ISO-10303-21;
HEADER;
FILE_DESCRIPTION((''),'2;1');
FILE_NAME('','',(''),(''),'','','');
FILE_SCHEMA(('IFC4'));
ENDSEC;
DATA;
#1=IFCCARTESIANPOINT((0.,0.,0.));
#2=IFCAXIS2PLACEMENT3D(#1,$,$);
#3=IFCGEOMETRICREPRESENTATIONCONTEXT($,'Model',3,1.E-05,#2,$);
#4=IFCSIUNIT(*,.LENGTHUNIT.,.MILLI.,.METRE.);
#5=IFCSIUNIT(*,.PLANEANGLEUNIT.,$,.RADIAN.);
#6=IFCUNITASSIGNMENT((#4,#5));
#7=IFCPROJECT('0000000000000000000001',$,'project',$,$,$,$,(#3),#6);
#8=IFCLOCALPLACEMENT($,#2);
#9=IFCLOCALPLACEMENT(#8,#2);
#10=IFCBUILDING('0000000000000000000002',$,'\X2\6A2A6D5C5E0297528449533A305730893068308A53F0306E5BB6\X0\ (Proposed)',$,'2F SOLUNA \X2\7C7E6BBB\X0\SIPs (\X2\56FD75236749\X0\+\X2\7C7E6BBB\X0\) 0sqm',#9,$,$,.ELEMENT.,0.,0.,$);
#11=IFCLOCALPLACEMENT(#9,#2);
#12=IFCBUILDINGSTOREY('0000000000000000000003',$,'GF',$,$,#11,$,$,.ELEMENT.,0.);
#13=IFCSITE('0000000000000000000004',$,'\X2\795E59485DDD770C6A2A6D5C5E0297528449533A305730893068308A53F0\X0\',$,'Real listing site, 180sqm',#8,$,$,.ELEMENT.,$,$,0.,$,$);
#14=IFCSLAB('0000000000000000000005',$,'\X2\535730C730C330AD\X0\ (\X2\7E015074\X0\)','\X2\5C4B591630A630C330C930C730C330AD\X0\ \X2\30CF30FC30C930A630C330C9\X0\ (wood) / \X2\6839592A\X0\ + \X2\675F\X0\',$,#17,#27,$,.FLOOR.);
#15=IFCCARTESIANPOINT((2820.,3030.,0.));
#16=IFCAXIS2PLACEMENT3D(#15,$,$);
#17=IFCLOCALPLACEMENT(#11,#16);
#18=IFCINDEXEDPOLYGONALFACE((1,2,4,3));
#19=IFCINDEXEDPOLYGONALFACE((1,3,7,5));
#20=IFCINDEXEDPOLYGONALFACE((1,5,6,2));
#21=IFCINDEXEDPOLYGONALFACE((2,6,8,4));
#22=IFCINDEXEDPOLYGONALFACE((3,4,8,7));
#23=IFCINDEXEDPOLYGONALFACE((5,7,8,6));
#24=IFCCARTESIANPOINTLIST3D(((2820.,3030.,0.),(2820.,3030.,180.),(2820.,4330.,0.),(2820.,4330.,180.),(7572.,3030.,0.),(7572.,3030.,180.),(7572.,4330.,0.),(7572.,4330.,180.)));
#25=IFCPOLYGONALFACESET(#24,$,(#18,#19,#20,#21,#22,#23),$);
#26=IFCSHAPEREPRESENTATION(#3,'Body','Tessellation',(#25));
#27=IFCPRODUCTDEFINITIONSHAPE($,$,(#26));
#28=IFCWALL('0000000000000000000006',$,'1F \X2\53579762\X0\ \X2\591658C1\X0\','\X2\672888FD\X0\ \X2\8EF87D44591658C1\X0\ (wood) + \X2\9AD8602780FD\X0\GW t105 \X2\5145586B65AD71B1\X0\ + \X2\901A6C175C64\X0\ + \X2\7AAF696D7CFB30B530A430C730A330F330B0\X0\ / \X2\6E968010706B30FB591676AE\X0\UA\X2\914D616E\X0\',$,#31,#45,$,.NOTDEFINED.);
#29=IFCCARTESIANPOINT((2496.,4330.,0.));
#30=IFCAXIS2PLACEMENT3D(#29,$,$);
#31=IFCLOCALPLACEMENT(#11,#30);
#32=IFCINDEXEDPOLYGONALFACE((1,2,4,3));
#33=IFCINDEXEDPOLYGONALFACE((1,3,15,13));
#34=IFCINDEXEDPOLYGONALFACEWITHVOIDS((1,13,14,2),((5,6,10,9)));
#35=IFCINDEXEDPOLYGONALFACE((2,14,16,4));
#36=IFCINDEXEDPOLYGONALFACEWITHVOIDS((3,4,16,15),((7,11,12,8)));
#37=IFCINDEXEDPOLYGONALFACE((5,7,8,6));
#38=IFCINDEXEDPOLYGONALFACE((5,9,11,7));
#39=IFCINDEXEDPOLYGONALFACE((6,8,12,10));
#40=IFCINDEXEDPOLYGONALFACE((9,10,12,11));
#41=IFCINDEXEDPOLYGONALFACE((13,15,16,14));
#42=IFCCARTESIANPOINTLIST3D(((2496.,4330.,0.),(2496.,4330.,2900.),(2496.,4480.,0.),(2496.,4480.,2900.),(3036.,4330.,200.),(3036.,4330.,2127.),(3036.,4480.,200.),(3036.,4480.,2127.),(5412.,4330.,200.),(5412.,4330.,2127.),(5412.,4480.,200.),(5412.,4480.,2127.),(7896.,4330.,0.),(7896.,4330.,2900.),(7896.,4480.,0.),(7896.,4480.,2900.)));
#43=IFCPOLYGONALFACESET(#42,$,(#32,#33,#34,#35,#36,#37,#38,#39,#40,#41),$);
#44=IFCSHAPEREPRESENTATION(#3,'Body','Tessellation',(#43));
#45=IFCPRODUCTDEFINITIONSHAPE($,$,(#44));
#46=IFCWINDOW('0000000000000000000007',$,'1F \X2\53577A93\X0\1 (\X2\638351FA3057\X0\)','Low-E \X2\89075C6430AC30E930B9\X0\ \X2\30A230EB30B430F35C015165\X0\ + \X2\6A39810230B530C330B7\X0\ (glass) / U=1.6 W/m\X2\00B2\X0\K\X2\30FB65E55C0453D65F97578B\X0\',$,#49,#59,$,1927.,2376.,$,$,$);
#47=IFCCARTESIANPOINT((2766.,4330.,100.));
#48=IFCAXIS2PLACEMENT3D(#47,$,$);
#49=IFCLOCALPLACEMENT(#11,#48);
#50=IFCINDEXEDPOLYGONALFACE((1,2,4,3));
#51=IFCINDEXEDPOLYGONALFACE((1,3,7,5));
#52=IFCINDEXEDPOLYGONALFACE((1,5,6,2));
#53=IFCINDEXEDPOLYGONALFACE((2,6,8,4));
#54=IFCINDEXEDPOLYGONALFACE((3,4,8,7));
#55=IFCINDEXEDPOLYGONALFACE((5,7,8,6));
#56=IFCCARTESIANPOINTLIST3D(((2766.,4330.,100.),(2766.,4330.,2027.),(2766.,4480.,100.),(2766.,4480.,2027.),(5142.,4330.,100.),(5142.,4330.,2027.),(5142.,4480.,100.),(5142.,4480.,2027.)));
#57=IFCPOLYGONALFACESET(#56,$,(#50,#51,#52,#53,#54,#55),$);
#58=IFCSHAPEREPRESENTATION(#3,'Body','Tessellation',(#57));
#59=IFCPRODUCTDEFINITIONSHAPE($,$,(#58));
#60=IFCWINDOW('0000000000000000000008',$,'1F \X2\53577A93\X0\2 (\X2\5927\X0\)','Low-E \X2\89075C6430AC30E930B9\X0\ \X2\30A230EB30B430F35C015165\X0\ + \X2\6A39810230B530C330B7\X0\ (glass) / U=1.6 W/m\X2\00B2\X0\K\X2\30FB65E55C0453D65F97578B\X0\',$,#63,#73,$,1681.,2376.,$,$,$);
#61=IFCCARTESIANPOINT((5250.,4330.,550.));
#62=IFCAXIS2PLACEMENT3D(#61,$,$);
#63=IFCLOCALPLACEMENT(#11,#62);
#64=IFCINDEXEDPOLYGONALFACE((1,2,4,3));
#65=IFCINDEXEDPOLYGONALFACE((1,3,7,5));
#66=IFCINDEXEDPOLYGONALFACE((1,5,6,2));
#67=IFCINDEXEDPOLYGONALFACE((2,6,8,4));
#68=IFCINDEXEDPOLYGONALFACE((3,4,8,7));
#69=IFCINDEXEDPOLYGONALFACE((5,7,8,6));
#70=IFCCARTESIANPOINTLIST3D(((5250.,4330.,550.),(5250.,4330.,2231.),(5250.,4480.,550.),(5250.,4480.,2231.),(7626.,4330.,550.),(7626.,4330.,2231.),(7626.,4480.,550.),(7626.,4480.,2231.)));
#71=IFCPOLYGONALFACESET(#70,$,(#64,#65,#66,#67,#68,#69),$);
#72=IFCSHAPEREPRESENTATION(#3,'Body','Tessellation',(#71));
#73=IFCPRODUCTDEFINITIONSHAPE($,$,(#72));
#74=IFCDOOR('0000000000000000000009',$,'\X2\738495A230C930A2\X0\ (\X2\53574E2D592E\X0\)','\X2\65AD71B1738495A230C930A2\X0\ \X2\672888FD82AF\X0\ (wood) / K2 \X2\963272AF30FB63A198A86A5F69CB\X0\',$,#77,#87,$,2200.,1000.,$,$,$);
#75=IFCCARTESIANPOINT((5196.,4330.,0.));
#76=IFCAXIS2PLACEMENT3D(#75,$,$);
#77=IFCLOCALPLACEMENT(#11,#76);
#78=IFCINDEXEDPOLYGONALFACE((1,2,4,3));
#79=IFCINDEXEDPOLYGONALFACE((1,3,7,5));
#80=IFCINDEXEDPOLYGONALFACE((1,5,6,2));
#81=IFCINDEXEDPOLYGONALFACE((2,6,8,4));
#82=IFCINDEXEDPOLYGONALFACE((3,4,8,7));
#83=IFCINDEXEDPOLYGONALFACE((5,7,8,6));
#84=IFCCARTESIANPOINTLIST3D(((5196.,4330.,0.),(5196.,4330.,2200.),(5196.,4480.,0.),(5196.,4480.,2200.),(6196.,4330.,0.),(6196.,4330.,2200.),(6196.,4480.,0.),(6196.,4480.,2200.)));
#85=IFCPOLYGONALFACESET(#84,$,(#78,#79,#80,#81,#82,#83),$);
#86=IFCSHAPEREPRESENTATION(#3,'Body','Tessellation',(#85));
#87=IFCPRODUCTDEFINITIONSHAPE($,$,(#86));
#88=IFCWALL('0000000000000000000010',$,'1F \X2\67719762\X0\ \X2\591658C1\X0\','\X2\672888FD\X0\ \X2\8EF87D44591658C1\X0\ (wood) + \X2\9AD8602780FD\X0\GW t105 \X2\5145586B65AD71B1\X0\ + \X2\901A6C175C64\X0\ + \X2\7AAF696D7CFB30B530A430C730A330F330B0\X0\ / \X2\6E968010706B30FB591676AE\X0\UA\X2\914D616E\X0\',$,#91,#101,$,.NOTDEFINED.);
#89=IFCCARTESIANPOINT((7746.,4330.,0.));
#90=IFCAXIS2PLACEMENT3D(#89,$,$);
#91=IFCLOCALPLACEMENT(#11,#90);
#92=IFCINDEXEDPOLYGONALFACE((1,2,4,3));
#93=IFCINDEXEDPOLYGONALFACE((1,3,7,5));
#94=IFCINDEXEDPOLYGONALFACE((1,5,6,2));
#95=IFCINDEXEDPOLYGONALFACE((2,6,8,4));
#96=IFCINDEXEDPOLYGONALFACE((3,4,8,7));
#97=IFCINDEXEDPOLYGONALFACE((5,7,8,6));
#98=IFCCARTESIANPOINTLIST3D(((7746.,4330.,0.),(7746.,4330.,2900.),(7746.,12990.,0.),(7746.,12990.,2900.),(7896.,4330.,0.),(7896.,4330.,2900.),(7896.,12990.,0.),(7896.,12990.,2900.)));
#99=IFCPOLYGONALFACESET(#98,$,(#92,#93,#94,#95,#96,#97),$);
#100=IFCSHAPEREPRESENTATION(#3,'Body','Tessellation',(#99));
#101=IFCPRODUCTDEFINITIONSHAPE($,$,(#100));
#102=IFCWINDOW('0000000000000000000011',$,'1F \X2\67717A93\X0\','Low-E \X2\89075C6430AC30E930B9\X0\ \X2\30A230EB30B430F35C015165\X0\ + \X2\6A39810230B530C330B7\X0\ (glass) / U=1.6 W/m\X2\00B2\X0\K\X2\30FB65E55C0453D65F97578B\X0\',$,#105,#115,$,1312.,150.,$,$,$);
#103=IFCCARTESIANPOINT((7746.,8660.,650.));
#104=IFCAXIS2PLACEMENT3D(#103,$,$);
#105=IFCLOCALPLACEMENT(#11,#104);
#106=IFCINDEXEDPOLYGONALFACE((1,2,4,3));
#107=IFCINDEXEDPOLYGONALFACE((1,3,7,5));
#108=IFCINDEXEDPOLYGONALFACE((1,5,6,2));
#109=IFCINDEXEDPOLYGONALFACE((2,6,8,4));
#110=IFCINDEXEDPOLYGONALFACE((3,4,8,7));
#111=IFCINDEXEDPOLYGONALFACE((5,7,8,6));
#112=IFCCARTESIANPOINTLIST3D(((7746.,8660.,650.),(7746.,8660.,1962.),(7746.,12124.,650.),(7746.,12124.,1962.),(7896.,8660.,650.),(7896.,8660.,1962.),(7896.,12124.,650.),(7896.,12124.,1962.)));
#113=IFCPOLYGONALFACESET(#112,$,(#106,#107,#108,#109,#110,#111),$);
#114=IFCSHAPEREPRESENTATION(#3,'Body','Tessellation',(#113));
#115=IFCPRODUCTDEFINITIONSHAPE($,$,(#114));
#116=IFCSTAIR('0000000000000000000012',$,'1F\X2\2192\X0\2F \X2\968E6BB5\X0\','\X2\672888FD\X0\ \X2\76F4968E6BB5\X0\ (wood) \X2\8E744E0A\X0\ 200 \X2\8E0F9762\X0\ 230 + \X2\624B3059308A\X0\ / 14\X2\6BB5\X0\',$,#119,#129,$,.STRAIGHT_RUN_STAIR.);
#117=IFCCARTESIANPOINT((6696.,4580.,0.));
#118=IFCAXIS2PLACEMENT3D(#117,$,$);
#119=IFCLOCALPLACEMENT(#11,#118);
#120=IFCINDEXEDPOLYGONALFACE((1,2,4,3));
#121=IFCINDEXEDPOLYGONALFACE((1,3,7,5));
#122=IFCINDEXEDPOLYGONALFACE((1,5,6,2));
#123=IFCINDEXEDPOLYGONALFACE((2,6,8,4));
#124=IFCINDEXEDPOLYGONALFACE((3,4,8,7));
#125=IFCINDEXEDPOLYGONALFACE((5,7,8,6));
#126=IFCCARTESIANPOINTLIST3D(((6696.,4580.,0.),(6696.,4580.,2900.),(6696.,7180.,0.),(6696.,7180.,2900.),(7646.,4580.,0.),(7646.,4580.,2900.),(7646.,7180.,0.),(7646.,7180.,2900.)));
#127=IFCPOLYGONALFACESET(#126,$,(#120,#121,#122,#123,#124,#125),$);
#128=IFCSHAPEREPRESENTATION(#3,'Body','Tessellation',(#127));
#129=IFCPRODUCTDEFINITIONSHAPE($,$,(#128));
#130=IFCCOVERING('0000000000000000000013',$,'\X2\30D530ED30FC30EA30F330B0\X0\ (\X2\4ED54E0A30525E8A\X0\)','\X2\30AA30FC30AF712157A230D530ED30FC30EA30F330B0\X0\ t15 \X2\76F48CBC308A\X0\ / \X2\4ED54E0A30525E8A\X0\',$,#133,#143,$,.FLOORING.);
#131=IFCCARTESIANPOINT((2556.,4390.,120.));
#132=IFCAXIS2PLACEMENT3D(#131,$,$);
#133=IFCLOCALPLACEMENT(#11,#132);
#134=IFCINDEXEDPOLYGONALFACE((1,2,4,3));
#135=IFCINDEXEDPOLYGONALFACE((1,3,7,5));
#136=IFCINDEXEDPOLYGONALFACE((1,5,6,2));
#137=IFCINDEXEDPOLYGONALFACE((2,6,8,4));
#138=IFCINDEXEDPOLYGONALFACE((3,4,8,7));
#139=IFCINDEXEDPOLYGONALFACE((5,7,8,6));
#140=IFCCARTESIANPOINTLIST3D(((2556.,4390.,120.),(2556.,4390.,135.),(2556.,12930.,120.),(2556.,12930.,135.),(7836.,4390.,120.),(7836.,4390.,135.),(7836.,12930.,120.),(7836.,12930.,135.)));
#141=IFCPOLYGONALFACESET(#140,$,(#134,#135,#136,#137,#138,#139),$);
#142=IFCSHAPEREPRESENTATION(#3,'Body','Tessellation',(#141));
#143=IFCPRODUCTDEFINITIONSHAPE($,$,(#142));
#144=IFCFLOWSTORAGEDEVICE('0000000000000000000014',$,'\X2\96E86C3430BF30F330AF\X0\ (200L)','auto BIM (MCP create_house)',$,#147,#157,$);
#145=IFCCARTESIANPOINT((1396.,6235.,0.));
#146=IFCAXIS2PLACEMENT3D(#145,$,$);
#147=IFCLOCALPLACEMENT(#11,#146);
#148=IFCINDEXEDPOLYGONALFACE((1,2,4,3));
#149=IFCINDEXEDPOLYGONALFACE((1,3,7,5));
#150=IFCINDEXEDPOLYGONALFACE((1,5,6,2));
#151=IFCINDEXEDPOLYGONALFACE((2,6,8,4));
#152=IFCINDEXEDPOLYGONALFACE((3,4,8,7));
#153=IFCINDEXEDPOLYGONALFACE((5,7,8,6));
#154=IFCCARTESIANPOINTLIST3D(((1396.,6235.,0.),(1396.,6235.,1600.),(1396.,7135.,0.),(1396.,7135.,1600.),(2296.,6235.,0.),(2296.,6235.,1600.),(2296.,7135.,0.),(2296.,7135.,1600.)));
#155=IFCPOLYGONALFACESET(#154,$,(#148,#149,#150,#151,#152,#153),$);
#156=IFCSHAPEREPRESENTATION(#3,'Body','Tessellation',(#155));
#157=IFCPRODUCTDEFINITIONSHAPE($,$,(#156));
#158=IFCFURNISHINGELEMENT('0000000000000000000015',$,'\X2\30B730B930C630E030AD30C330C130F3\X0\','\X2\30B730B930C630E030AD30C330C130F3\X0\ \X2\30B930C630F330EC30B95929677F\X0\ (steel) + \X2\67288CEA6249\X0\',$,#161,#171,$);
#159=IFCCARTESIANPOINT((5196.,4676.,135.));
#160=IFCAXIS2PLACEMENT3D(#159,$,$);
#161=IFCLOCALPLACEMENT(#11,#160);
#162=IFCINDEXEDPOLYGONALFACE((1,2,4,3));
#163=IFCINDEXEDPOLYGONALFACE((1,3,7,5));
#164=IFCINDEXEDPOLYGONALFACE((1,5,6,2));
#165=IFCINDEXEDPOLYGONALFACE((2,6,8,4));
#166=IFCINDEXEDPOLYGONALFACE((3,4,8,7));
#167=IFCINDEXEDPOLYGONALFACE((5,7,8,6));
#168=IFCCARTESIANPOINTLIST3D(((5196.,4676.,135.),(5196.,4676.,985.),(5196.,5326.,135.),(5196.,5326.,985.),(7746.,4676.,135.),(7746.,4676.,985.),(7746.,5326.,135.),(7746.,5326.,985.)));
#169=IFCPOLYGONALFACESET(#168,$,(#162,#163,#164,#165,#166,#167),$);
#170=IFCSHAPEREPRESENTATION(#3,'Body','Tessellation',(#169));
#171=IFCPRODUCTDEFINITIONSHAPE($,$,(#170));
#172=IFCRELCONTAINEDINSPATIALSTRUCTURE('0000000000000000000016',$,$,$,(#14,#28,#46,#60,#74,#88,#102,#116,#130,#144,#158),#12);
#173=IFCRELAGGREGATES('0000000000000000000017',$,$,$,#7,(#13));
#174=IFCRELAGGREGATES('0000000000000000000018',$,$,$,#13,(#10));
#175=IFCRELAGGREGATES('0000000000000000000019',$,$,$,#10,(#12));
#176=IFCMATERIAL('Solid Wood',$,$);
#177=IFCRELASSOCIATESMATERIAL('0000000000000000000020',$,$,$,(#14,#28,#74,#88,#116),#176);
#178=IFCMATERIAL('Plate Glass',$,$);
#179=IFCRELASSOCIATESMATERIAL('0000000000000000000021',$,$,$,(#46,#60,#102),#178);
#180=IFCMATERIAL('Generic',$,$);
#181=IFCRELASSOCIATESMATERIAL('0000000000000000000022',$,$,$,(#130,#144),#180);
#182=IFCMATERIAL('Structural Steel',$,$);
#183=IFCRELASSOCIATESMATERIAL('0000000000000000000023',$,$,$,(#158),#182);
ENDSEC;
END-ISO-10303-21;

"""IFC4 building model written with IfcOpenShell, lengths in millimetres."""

from ifc_helpers import new_model, si_unit, frame, frame_2d, origin, place, context, project, spatial, rectangle, extrude, material, element, fill, save


model = new_model("IFC4")

# Units and contexts
model_context = context("Model", 3, precision=1e-05, world=origin())
ifc_project = project(units=[si_unit("LENGTHUNIT", "METRE", prefix="MILLI"), si_unit("PLANEANGLEUNIT", "RADIAN")], contexts=[model_context])

# Site, building, storey
site_placement = place(None, origin())
site = spatial("IfcSite", under=ifc_project, at=site_placement, Name="神奈川県横浜市青葉区しらとり台", ObjectType="Real listing site, 180sqm", CompositionType="ELEMENT", RefElevation=0.0)
building_placement = place(site_placement, origin())
building = spatial("IfcBuilding", under=site, at=building_placement, Name="横浜市青葉区しらとり台の家 (Proposed)", ObjectType="2F SOLUNA 籾殻SIPs (国産杉+籾殻) 0sqm", CompositionType="ELEMENT", ElevationOfRefHeight=0.0, ElevationOfTerrain=0.0)
storey_placement = place(building_placement, origin())
storey = spatial("IfcBuildingStorey", under=building, at=storey_placement, Name="GF", CompositionType="ELEMENT", Elevation=0.0)

# Slab
ifc_material_1 = material(Name="Solid Wood")
slab_1_placement = place(storey_placement, frame((2820.0, 3030.0, 0.0)))
element("IfcSlab", 1, at=slab_1_placement, inside=storey, material=ifc_material_1, Name="南デッキ (縁側)", Description="屋外ウッドデッキ ハードウッド (wood) / 根太 + 束", PredefinedType="FLOOR", context=model_context, shape_type="SweptSolid", body=[
    extrude(rectangle(XDim=4752.0, YDim=1300.0, at=frame_2d((2376.0, 650.0))), frame((2820.0, 3030.0, 0.0)), (0.0, 0.0, 1.0), 180.0),
])

# Wall, openings, windows, door
wall_1_placement = place(storey_placement, frame((2496.0, 4330.0, 0.0)))
wall_1 = element("IfcWall", 2, at=wall_1_placement, inside=storey, material=ifc_material_1, Name="1F 南面 外壁", Description="木製 軸組外壁 (wood) + 高性能GW t105 充填断熱 + 通気層 + 窯業系サイディング / 準耐火・外皮UA配慮", PredefinedType="NOTDEFINED", context=model_context, shape_type="SweptSolid", body=[
    extrude(rectangle(XDim=5400.0, YDim=150.0, at=frame_2d((2700.0, 75.0))), frame((2496.0, 4330.0, 0.0)), (0.0, 0.0, 1.0), 2900.0),
])
opening_1_placement = place(storey_placement, frame((2766.0, 4330.0, 100.0)))
opening_1 = element("IfcOpeningElement", 3, at=opening_1_placement, cuts=wall_1, PredefinedType="NOTDEFINED", context=model_context, shape_type="SweptSolid", body=[
    extrude(rectangle(XDim=2376.0, YDim=150.0, at=frame_2d((1188.0, 75.0))), frame((2766.0, 4330.0, 100.0)), (0.0, 0.0, 1.0), 1927.0),
])
opening_2_placement = place(storey_placement, frame((5250.0, 4330.0, 550.0)))
opening_2 = element("IfcOpeningElement", 4, at=opening_2_placement, cuts=wall_1, PredefinedType="NOTDEFINED", context=model_context, shape_type="SweptSolid", body=[
    extrude(rectangle(XDim=2376.0, YDim=150.0, at=frame_2d((1188.0, 75.0))), frame((5250.0, 4330.0, 550.0)), (0.0, 0.0, 1.0), 1681.0),
])
opening_3_placement = place(storey_placement, frame((5196.0, 4330.0, 0.0)))
opening_3 = element("IfcOpeningElement", 5, at=opening_3_placement, cuts=wall_1, PredefinedType="NOTDEFINED", context=model_context, shape_type="SweptSolid", body=[
    extrude(rectangle(XDim=1000.0, YDim=150.0, at=frame_2d((500.0, 75.0))), frame((5196.0, 4330.0, 0.0)), (0.0, 0.0, 1.0), 2200.0),
])
ifc_material_2 = material(Name="Plate Glass")
window_1_placement = place(storey_placement, frame((2766.0, 4330.0, 100.0)))
window_1 = element("IfcWindow", 6, at=window_1_placement, inside=storey, material=ifc_material_2, Name="1F 南窓1 (掃出し)", Description="Low-E 複層ガラス アルゴン封入 + 樹脂サッシ (glass) / U=1.6 W/m²K・日射取得型", OverallHeight=1927.0, OverallWidth=2376.0, context=model_context, shape_type="SweptSolid", body=[
    extrude(rectangle(XDim=2376.0, YDim=150.0, at=frame_2d((1188.0, 75.0))), frame((2766.0, 4330.0, 100.0)), (0.0, 0.0, 1.0), 1927.0),
])
fill(opening_1, window_1)
window_2_placement = place(storey_placement, frame((5250.0, 4330.0, 550.0)))
window_2 = element("IfcWindow", 7, at=window_2_placement, inside=storey, material=ifc_material_2, Name="1F 南窓2 (大)", Description="Low-E 複層ガラス アルゴン封入 + 樹脂サッシ (glass) / U=1.6 W/m²K・日射取得型", OverallHeight=1681.0, OverallWidth=2376.0, context=model_context, shape_type="SweptSolid", body=[
    extrude(rectangle(XDim=2376.0, YDim=150.0, at=frame_2d((1188.0, 75.0))), frame((5250.0, 4330.0, 550.0)), (0.0, 0.0, 1.0), 1681.0),
])
fill(opening_2, window_2)
door_placement = place(storey_placement, frame((5196.0, 4330.0, 0.0)))
door = element("IfcDoor", 8, at=door_placement, inside=storey, material=ifc_material_1, Name="玄関ドア (南中央)", Description="断熱玄関ドア 木製芯 (wood) / K2 防犯・採風機構", OverallHeight=2200.0, OverallWidth=1000.0, context=model_context, shape_type="SweptSolid", body=[
    extrude(rectangle(XDim=1000.0, YDim=150.0, at=frame_2d((500.0, 75.0))), frame((5196.0, 4330.0, 0.0)), (0.0, 0.0, 1.0), 2200.0),
])
fill(opening_3, door)

# Wall, opening, window
wall_2_placement = place(storey_placement, frame((7746.0, 4330.0, 0.0)))
wall_2 = element("IfcWall", 9, at=wall_2_placement, inside=storey, material=ifc_material_1, Name="1F 東面 外壁", Description="木製 軸組外壁 (wood) + 高性能GW t105 充填断熱 + 通気層 + 窯業系サイディング / 準耐火・外皮UA配慮", PredefinedType="NOTDEFINED", context=model_context, shape_type="SweptSolid", body=[
    extrude(rectangle(XDim=150.0, YDim=8660.0, at=frame_2d((75.0, 4330.0))), frame((7746.0, 4330.0, 0.0)), (0.0, 0.0, 1.0), 2900.0),
])
opening_4_placement = place(storey_placement, frame((7746.0, 8660.0, 650.0)))
opening_4 = element("IfcOpeningElement", 10, at=opening_4_placement, cuts=wall_2, PredefinedType="NOTDEFINED", context=model_context, shape_type="SweptSolid", body=[
    extrude(rectangle(XDim=150.0, YDim=3464.0, at=frame_2d((75.0, 1732.0))), frame((7746.0, 8660.0, 650.0)), (0.0, 0.0, 1.0), 1312.0),
])
window_3_placement = place(storey_placement, frame((7746.0, 8660.0, 650.0)))
window_3 = element("IfcWindow", 11, at=window_3_placement, inside=storey, material=ifc_material_2, Name="1F 東窓", Description="Low-E 複層ガラス アルゴン封入 + 樹脂サッシ (glass) / U=1.6 W/m²K・日射取得型", OverallHeight=1312.0, OverallWidth=150.0, context=model_context, shape_type="SweptSolid", body=[
    extrude(rectangle(XDim=150.0, YDim=3464.0, at=frame_2d((75.0, 1732.0))), frame((7746.0, 8660.0, 650.0)), (0.0, 0.0, 1.0), 1312.0),
])
fill(opening_4, window_3)

# Stair
stair_placement = place(storey_placement, frame((6696.0, 4580.0, 0.0)))
element("IfcStair", 12, at=stair_placement, inside=storey, material=ifc_material_1, Name="1F→2F 階段", Description="木製 直階段 (wood) 蹴上 200 踏面 230 + 手すり / 14段", PredefinedType="STRAIGHT_RUN_STAIR", context=model_context, shape_type="SweptSolid", body=[
    extrude(rectangle(XDim=950.0, YDim=2600.0, at=frame_2d((475.0, 1300.0))), frame((6696.0, 4580.0, 0.0)), (0.0, 0.0, 1.0), 2900.0),
])

# Covering
ifc_material_3 = material(Name="Generic")
covering_placement = place(storey_placement, frame((2556.0, 4390.0, 120.0)))
element("IfcCovering", 13, at=covering_placement, inside=storey, material=ifc_material_3, Name="フローリング (仕上げ床)", Description="オーク無垢フローリング t15 直貼り / 仕上げ床", PredefinedType="FLOORING", context=model_context, shape_type="SweptSolid", body=[
    extrude(rectangle(XDim=5280.0, YDim=8540.0, at=frame_2d((2640.0, 4270.0))), frame((2556.0, 4390.0, 120.0)), (0.0, 0.0, 1.0), 15.0),
])

# Flow storage device
flow_storage_device_placement = place(storey_placement, frame((1396.0, 6235.0, 0.0)))
element("IfcFlowStorageDevice", 14, at=flow_storage_device_placement, inside=storey, material=ifc_material_3, Name="雨水タンク (200L)", Description="auto BIM (MCP create_house)", context=model_context, shape_type="SweptSolid", body=[
    extrude(rectangle(XDim=900.0, YDim=900.0, at=frame_2d((450.0, 450.0))), frame((1396.0, 6235.0, 0.0)), (0.0, 0.0, 1.0), 1600.0),
])

# Furnishing element
ifc_material_4 = material(Name="Structural Steel")
furnishing_placement = place(storey_placement, frame((5196.0, 4676.0, 135.0)))
element("IfcFurnishingElement", 15, at=furnishing_placement, inside=storey, material=ifc_material_4, Name="システムキッチン", Description="システムキッチン ステンレス天板 (steel) + 木質扉", context=model_context, shape_type="SweptSolid", body=[
    extrude(rectangle(XDim=2550.0, YDim=650.0, at=frame_2d((1275.0, 325.0))), frame((5196.0, 4676.0, 135.0)), (0.0, 0.0, 1.0), 850.0),
])

save(model, "model.ifc")
